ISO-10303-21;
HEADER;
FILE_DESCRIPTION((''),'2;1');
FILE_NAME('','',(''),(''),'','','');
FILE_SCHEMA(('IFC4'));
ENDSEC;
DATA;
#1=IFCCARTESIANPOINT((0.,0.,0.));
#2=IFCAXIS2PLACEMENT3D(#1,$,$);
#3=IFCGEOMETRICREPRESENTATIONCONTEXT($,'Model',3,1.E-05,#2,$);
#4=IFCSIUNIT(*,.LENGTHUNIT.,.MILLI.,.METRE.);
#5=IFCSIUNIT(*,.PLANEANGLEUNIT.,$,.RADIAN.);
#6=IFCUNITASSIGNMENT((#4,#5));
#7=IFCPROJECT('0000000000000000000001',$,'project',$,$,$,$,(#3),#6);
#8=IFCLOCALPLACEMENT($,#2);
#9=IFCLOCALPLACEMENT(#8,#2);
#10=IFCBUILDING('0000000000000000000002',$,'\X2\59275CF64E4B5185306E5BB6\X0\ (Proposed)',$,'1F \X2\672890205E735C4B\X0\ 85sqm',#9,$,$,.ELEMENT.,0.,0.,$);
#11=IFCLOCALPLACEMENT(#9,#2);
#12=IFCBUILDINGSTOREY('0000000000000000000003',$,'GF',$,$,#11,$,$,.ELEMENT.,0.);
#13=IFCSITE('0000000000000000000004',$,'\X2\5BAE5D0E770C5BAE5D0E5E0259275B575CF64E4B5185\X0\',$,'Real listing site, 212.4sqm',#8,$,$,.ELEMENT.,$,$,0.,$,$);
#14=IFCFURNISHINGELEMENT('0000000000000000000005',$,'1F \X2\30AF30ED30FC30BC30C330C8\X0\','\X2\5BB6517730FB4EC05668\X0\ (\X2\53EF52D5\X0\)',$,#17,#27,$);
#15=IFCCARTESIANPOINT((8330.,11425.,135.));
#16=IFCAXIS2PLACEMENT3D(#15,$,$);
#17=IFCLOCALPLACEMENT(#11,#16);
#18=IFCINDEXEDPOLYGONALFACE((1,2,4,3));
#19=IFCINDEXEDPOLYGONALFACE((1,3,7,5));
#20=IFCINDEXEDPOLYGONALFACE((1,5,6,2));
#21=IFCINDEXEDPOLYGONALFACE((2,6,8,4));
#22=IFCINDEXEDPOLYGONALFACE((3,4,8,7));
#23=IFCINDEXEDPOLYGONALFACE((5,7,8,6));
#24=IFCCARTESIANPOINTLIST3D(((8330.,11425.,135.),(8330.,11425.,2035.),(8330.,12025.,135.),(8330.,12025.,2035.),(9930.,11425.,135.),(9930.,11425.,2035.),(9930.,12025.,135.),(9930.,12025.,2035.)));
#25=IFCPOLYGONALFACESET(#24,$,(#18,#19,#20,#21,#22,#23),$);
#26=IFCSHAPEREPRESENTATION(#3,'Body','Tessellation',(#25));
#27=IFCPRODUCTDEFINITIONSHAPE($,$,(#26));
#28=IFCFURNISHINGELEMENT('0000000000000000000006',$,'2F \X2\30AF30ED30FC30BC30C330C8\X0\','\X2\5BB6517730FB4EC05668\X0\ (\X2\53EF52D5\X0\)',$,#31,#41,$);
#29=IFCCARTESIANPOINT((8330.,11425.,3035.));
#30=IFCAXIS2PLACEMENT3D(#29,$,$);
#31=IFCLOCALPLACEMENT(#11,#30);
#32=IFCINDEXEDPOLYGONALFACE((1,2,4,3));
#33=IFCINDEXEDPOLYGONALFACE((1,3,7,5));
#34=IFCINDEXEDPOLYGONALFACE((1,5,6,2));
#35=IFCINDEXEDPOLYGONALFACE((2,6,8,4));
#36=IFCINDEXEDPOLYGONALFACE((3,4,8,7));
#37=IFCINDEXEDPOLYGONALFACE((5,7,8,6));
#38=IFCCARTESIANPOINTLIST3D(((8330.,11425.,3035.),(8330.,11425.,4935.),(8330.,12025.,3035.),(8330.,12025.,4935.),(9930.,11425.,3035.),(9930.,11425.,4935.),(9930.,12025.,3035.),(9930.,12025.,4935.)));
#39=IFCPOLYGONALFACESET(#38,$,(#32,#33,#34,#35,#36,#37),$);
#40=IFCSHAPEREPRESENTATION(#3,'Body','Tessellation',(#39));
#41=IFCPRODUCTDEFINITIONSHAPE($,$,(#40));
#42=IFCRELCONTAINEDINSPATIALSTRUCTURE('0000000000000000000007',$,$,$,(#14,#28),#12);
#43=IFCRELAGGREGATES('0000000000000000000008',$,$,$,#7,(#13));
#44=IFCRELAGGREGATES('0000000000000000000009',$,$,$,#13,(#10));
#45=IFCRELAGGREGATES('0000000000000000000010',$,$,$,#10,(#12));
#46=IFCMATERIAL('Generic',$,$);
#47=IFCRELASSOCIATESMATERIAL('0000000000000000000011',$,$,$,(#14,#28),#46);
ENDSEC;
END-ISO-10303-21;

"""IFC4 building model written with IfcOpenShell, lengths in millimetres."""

from ifc_helpers import new_model, si_unit, frame, frame_2d, origin, place, context, project, spatial, rectangle, extrude, material, element, save


model = new_model("IFC4")

# Units and contexts
model_context = context("Model", 3, precision=1e-05, world=origin())
ifc_project = project(units=[si_unit("LENGTHUNIT", "METRE", prefix="MILLI"), si_unit("PLANEANGLEUNIT", "RADIAN")], contexts=[model_context])

# Site, building, storey
site_placement = place(None, origin())
site = spatial("IfcSite", under=ifc_project, at=site_placement, Name="宮崎県宮崎市大字島之内", ObjectType="Real listing site, 212.4sqm", CompositionType="ELEMENT", RefElevation=0.0)
building_placement = place(site_placement, origin())
building = spatial("IfcBuilding", under=site, at=building_placement, Name="大島之内の家 (Proposed)", ObjectType="1F 木造平屋 85sqm", CompositionType="ELEMENT", ElevationOfRefHeight=0.0, ElevationOfTerrain=0.0)
storey_placement = place(building_placement, origin())
storey = spatial("IfcBuildingStorey", under=building, at=storey_placement, Name="GF", CompositionType="ELEMENT", Elevation=0.0)

# Shared definitions
ifc_material_1 = material(Name="Generic")

# Furnishing elements
furnishing_1_placement = place(storey_placement, frame((8330.0, 11425.0, 135.0)))
element("IfcFurnishingElement", 1, at=furnishing_1_placement, inside=storey, material=ifc_material_1, Name="1F クローゼット", Description="家具・什器 (可動)", context=model_context, shape_type="SweptSolid", body=[
    extrude(rectangle(XDim=1600.0, YDim=600.0, at=frame_2d((800.0, 300.0))), frame((8330.0, 11425.0, 135.0)), (0.0, 0.0, 1.0), 1900.0),
])
furnishing_2_placement = place(storey_placement, frame((8330.0, 11425.0, 3035.0)))
element("IfcFurnishingElement", 2, at=furnishing_2_placement, inside=storey, material=ifc_material_1, Name="2F クローゼット", Description="家具・什器 (可動)", context=model_context, shape_type="SweptSolid", body=[
    extrude(rectangle(XDim=1600.0, YDim=600.0, at=frame_2d((800.0, 300.0))), frame((8330.0, 11425.0, 3035.0)), (0.0, 0.0, 1.0), 1900.0),
])

save(model, "model.ifc")
